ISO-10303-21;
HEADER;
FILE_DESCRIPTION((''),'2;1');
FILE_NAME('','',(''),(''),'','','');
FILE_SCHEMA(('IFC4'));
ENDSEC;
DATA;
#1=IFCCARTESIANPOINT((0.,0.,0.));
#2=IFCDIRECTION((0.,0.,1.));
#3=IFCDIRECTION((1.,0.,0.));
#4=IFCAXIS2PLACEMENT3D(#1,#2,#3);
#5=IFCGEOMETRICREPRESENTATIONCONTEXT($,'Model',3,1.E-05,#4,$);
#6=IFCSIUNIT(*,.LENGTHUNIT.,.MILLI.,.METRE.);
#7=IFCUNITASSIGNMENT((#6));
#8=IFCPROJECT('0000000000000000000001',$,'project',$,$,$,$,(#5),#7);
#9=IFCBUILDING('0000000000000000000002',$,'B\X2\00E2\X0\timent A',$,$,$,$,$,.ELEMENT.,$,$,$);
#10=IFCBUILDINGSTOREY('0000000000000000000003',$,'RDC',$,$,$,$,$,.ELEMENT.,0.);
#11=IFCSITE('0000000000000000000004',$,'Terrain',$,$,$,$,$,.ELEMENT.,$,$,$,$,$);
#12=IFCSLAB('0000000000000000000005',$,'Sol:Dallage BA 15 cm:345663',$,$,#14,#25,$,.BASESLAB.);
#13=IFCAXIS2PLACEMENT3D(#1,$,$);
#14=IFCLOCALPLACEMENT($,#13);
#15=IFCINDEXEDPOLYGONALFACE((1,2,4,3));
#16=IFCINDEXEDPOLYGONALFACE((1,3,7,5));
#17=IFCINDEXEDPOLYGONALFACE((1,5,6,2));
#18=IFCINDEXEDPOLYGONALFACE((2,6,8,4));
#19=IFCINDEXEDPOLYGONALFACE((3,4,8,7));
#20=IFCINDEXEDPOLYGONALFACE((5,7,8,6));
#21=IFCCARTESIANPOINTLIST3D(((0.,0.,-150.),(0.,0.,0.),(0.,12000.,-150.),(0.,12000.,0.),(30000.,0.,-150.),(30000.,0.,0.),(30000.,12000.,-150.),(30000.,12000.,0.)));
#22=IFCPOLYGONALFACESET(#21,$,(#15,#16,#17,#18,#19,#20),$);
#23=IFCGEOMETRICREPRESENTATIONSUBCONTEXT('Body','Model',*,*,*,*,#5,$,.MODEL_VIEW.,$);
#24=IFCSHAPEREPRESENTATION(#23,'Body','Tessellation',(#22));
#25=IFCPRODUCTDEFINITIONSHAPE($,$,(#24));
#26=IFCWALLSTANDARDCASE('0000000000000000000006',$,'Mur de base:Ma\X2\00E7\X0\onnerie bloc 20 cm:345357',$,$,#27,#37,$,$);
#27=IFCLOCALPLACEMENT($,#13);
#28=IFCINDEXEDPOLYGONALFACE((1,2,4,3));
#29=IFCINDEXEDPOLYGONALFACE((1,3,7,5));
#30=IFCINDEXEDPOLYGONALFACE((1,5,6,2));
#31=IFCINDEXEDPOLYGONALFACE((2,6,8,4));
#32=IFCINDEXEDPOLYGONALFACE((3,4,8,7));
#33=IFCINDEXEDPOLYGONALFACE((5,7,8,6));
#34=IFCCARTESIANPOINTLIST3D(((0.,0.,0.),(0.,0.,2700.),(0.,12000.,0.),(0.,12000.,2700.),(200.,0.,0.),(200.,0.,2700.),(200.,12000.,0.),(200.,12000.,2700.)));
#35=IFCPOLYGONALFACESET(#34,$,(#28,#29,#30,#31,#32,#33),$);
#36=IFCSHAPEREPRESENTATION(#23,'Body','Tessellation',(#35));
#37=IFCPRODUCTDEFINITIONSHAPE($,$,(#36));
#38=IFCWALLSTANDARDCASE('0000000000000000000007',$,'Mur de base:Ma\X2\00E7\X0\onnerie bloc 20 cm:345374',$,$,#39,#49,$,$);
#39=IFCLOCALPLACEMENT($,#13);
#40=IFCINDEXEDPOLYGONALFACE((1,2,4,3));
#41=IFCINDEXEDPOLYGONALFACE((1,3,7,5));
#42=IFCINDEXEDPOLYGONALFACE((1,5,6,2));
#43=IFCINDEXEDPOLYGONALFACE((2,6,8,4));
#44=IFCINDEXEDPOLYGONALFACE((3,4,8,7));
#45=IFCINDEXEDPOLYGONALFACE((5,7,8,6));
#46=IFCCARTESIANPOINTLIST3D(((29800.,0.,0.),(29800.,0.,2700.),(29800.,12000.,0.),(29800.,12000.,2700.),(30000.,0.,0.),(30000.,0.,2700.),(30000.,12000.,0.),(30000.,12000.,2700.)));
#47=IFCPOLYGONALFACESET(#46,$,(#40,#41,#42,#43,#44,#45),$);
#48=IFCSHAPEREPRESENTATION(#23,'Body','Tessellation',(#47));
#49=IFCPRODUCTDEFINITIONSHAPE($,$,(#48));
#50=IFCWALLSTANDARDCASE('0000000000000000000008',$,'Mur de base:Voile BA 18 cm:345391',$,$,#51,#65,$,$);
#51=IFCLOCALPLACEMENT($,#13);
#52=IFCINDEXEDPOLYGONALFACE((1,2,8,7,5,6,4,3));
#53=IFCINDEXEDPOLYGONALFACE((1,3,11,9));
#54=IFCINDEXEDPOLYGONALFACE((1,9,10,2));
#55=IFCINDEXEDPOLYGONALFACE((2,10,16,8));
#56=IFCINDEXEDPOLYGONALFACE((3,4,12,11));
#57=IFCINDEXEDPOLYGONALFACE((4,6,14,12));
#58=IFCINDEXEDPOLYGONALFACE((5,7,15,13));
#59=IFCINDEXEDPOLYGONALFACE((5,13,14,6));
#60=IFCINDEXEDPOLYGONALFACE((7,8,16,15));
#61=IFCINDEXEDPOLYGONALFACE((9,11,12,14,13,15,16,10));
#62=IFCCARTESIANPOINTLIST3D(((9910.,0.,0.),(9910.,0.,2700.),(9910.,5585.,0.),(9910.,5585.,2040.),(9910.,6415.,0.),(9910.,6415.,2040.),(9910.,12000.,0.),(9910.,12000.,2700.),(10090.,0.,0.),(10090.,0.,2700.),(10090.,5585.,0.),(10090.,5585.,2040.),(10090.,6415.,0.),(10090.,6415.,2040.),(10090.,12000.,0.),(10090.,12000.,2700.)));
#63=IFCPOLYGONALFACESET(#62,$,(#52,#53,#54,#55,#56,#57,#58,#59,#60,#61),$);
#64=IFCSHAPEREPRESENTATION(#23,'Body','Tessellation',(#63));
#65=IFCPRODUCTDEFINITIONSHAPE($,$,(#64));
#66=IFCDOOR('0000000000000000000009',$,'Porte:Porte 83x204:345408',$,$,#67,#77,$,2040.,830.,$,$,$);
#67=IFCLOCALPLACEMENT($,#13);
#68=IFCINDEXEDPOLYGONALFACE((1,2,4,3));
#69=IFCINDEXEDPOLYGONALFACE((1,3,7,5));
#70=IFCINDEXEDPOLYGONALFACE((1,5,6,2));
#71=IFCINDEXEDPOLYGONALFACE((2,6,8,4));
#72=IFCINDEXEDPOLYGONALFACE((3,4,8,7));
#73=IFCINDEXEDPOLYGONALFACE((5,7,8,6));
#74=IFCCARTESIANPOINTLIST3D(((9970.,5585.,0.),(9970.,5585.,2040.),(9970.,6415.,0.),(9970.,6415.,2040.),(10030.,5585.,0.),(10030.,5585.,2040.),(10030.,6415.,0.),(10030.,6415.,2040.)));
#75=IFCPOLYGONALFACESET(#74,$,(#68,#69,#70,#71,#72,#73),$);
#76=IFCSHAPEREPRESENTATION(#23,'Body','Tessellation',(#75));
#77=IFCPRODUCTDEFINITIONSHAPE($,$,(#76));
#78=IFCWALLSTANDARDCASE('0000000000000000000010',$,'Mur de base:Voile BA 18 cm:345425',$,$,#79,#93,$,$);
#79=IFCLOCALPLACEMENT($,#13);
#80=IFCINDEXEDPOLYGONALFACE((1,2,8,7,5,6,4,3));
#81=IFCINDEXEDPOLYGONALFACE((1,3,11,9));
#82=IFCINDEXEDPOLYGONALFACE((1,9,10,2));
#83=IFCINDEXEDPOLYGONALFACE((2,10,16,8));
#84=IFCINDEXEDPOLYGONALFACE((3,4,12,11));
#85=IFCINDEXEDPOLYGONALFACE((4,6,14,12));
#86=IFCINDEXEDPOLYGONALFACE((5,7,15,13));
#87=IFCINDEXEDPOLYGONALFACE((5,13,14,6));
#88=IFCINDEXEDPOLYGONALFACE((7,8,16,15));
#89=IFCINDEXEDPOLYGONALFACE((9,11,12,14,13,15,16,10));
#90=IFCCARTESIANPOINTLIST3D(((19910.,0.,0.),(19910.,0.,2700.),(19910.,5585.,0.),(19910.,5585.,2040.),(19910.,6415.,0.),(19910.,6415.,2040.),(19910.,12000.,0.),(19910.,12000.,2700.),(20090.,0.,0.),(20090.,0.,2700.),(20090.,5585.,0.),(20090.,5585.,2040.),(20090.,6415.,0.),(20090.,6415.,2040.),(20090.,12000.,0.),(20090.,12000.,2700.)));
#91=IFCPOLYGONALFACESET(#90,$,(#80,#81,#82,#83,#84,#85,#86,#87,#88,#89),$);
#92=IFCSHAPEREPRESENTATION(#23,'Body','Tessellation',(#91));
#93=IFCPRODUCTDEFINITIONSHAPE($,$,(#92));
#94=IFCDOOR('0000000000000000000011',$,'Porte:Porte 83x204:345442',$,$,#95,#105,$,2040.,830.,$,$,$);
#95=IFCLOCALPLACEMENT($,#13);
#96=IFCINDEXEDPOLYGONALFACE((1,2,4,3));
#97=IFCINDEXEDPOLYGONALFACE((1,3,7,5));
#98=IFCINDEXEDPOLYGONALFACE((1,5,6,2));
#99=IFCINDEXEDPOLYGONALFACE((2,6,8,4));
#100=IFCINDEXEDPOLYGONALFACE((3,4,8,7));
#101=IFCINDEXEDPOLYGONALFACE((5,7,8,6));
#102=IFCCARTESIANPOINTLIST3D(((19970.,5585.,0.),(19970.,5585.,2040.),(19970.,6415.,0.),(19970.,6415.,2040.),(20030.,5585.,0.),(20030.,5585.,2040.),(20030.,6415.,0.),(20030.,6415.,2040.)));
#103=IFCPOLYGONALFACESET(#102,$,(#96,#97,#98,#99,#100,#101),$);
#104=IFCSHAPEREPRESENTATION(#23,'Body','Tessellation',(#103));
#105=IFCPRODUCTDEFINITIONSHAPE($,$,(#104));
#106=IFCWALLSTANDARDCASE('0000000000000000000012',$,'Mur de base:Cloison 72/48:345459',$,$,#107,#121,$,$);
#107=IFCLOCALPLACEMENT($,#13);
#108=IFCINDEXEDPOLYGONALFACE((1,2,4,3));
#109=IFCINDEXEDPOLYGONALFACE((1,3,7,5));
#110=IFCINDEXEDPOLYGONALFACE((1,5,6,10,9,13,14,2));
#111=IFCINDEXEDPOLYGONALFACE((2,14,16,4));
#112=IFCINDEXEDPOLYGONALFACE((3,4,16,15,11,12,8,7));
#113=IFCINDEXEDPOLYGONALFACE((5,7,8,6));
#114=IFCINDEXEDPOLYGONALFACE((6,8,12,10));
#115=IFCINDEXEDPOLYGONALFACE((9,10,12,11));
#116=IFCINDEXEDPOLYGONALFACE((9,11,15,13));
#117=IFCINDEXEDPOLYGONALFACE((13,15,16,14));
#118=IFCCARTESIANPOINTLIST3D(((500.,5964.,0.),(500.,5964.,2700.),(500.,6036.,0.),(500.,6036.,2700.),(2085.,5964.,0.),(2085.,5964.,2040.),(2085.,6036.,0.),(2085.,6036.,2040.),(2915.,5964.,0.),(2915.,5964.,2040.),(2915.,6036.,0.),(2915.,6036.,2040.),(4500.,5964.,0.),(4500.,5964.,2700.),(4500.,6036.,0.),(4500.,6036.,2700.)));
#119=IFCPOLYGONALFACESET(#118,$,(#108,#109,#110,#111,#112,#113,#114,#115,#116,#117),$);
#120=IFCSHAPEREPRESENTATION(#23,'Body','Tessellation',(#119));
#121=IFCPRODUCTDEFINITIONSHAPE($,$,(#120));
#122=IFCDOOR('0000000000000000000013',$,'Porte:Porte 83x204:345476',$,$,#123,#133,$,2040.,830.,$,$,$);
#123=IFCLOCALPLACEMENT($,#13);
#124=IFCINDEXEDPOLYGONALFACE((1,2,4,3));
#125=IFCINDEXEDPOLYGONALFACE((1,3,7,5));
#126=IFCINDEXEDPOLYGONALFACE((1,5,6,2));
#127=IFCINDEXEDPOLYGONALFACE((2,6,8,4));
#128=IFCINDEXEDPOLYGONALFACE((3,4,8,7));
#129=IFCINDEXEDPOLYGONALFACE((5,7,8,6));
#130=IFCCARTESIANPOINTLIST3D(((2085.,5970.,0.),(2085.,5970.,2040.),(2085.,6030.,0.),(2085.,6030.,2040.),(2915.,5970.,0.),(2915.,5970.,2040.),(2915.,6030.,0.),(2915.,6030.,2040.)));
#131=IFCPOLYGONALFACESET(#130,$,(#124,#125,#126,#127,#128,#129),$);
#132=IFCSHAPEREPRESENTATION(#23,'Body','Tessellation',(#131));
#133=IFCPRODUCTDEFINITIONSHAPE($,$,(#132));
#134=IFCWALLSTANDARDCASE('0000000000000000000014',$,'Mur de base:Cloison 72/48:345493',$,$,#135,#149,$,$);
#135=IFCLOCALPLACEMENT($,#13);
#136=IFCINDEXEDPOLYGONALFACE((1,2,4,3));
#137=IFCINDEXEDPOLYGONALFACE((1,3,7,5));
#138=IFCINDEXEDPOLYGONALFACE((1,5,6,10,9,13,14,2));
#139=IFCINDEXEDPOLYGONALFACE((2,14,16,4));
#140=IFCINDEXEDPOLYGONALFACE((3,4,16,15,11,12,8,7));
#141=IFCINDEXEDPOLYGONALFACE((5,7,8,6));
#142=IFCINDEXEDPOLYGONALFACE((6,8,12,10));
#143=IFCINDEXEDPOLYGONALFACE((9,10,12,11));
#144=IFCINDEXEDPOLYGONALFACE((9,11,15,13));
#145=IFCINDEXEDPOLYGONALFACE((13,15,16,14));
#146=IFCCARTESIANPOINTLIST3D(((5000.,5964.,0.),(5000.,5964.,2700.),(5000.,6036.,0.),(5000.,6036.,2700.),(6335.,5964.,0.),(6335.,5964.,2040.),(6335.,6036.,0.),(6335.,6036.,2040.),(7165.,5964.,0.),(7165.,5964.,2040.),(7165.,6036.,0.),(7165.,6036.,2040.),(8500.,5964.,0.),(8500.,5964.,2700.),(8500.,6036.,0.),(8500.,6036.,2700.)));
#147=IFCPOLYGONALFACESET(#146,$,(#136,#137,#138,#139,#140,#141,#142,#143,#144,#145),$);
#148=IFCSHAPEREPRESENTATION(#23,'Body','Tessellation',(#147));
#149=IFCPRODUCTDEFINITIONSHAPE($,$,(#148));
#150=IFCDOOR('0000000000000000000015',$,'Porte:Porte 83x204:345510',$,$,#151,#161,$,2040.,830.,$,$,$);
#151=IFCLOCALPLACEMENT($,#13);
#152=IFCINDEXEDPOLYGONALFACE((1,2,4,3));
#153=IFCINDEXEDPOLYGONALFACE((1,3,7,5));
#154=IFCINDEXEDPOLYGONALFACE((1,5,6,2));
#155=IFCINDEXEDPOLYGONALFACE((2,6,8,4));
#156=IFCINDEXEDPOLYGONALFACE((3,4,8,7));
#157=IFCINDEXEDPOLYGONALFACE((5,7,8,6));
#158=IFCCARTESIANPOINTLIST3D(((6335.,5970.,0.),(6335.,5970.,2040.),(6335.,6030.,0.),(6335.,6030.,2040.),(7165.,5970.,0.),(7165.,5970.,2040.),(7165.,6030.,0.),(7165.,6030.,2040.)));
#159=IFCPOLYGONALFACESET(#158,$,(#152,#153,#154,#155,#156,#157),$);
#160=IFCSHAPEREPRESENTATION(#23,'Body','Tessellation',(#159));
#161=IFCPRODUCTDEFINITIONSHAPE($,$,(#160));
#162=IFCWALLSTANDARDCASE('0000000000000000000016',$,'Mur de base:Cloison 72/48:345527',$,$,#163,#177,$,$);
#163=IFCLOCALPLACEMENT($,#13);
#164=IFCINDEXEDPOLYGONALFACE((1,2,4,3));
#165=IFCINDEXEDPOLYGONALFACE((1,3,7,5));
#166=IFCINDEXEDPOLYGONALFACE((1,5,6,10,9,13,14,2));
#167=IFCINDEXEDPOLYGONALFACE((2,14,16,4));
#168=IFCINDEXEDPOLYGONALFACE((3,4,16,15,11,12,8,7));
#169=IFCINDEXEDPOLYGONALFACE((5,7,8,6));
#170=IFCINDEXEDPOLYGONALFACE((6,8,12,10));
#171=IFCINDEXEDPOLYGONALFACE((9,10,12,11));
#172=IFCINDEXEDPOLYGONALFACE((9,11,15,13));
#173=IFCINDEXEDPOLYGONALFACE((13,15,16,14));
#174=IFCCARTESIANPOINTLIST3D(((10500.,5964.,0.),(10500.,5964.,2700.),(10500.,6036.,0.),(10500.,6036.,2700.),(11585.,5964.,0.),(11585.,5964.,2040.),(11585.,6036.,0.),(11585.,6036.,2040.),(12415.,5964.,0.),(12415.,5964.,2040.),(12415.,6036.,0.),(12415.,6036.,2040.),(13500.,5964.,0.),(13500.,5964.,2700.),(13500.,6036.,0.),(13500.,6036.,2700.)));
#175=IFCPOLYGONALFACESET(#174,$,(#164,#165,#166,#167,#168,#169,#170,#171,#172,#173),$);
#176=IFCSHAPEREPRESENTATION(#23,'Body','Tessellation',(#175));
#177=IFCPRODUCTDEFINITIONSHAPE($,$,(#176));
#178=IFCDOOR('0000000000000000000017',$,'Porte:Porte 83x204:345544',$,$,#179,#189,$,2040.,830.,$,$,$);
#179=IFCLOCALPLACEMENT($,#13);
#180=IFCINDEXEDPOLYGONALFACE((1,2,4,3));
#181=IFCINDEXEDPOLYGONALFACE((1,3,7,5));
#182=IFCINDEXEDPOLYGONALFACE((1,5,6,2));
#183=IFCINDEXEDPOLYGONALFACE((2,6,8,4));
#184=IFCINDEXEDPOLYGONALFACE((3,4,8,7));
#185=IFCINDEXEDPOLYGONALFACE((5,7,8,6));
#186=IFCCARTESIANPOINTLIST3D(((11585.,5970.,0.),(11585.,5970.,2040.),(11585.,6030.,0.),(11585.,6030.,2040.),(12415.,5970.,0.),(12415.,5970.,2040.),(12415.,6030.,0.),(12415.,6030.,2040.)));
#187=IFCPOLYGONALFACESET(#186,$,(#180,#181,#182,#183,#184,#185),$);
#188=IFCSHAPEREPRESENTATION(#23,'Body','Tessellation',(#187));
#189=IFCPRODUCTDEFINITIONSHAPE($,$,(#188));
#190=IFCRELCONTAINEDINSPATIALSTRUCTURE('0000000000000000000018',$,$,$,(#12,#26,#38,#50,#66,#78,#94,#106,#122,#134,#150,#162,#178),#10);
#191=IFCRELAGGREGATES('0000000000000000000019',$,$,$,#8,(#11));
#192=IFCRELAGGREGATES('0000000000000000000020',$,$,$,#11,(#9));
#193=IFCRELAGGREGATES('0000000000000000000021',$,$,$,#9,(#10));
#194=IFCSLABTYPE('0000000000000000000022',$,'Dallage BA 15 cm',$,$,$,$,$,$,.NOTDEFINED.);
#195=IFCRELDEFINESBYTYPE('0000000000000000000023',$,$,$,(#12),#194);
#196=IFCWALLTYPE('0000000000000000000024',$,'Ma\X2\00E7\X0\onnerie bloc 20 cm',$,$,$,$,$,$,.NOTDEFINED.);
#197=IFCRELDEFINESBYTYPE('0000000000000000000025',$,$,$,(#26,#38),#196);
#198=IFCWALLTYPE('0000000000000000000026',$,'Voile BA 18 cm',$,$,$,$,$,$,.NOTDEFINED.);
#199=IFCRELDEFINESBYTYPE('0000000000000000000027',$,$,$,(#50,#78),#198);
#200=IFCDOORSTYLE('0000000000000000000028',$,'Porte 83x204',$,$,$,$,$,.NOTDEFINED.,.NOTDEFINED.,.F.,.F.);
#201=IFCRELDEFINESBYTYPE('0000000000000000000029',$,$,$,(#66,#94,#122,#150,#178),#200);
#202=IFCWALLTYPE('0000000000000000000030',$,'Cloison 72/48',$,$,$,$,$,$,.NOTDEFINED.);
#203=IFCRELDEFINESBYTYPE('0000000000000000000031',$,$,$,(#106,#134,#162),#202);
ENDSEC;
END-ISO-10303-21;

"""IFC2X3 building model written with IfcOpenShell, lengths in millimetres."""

from ifc_helpers import new_model, si_unit, frame, frame_2d, origin_with_axes, place, context, subcontext, project, spatial, rectangle, extrude, type_object, element, fill, save


model = new_model("IFC2X3")

# Units and contexts
model_context = context("Model", 3, precision=1e-05, world=origin_with_axes())
body_context = subcontext(model_context, "Body", "Model", "MODEL_VIEW")
ifc_project = project(units=[si_unit("LENGTHUNIT", "METRE", prefix="MILLI")], contexts=[model_context])

# Site, building, storey
site = spatial("IfcSite", under=ifc_project, Name="Terrain", CompositionType="ELEMENT")
building = spatial("IfcBuilding", under=site, Name="Bâtiment A", CompositionType="ELEMENT")
storey = spatial("IfcBuildingStorey", under=building, Name="RDC", CompositionType="ELEMENT", Elevation=0.0)

# Slab
slab_type = type_object("IfcSlabType", Name="Dallage BA 15 cm", PredefinedType="NOTDEFINED")
slab_placement = place(None, origin_with_axes())
element("IfcSlab", 1, at=slab_placement, inside=storey, type_object=slab_type, Name="Sol:Dallage BA 15 cm:345663", PredefinedType="BASESLAB", context=body_context, shape_type="SweptSolid", body=[
    extrude(rectangle(XDim=30000.0, YDim=12000.0, at=frame_2d((15000.0, 6000.0))), frame((0.0, 0.0, -150.0), z_axis=(0.0, 0.0, 1.0), x_axis=(1.0, 0.0, 0.0)), (0.0, 0.0, 1.0), 150.0),
])

# Walls
wall_type_1 = type_object("IfcWallType", Name="Maçonnerie bloc 20 cm", PredefinedType="NOTDEFINED")
wall_1_placement = place(None, origin_with_axes())
element("IfcWallStandardCase", 2, at=wall_1_placement, inside=storey, type_object=wall_type_1, Name="Mur de base:Maçonnerie bloc 20 cm:345357", context=body_context, shape_type="SweptSolid", body=[
    extrude(rectangle(XDim=200.0, YDim=12000.0, at=frame_2d((100.0, 6000.0))), origin_with_axes(), (0.0, 0.0, 1.0), 2700.0),
])
wall_2_placement = place(None, origin_with_axes())
element("IfcWallStandardCase", 3, at=wall_2_placement, inside=storey, type_object=wall_type_1, Name="Mur de base:Maçonnerie bloc 20 cm:345374", context=body_context, shape_type="SweptSolid", body=[
    extrude(rectangle(XDim=200.0, YDim=12000.0, at=frame_2d((29900.0, 6000.0))), origin_with_axes(), (0.0, 0.0, 1.0), 2700.0),
])

# Walls, openings, doors
wall_type_2 = type_object("IfcWallType", Name="Voile BA 18 cm", PredefinedType="NOTDEFINED")
wall_3_placement = place(None, origin_with_axes())
wall_3 = element("IfcWallStandardCase", 4, at=wall_3_placement, inside=storey, type_object=wall_type_2, Name="Mur de base:Voile BA 18 cm:345391", context=body_context, shape_type="SweptSolid", body=[
    extrude(rectangle(XDim=180.0, YDim=12000.0, at=frame_2d((10000.0, 6000.0))), origin_with_axes(), (0.0, 0.0, 1.0), 2700.0),
])
opening_1_placement = place(None, origin_with_axes())
opening_1 = element("IfcOpeningElement", 5, at=opening_1_placement, cuts=wall_3, context=body_context, shape_type="SweptSolid", body=[
    extrude(rectangle(XDim=300.0, YDim=830.0, at=frame_2d((10000.0, 6000.0))), origin_with_axes(), (0.0, 0.0, 1.0), 2040.0),
])
door_style = type_object("IfcDoorStyle", Name="Porte 83x204", ConstructionType="NOTDEFINED", OperationType="NOTDEFINED", ParameterTakesPrecedence=False, Sizeable=False)
door_1_placement = place(None, origin_with_axes())
door_1 = element("IfcDoor", 6, at=door_1_placement, inside=storey, type_object=door_style, Name="Porte:Porte 83x204:345408", OverallHeight=2040.0, OverallWidth=830.0, context=body_context, shape_type="SweptSolid", body=[
    extrude(rectangle(XDim=60.0, YDim=830.0, at=frame_2d((10000.0, 6000.0))), origin_with_axes(), (0.0, 0.0, 1.0), 2040.0),
])
fill(opening_1, door_1)
wall_4_placement = place(None, origin_with_axes())
wall_4 = element("IfcWallStandardCase", 7, at=wall_4_placement, inside=storey, type_object=wall_type_2, Name="Mur de base:Voile BA 18 cm:345425", context=body_context, shape_type="SweptSolid", body=[
    extrude(rectangle(XDim=180.0, YDim=12000.0, at=frame_2d((20000.0, 6000.0))), origin_with_axes(), (0.0, 0.0, 1.0), 2700.0),
])
opening_2_placement = place(None, origin_with_axes())
opening_2 = element("IfcOpeningElement", 8, at=opening_2_placement, cuts=wall_4, context=body_context, shape_type="SweptSolid", body=[
    extrude(rectangle(XDim=300.0, YDim=830.0, at=frame_2d((20000.0, 6000.0))), origin_with_axes(), (0.0, 0.0, 1.0), 2040.0),
])
door_2_placement = place(None, origin_with_axes())
door_2 = element("IfcDoor", 9, at=door_2_placement, inside=storey, type_object=door_style, Name="Porte:Porte 83x204:345442", OverallHeight=2040.0, OverallWidth=830.0, context=body_context, shape_type="SweptSolid", body=[
    extrude(rectangle(XDim=60.0, YDim=830.0, at=frame_2d((20000.0, 6000.0))), origin_with_axes(), (0.0, 0.0, 1.0), 2040.0),
])
fill(opening_2, door_2)
wall_type_3 = type_object("IfcWallType", Name="Cloison 72/48", PredefinedType="NOTDEFINED")
wall_5_placement = place(None, origin_with_axes())
wall_5 = element("IfcWallStandardCase", 10, at=wall_5_placement, inside=storey, type_object=wall_type_3, Name="Mur de base:Cloison 72/48:345459", context=body_context, shape_type="SweptSolid", body=[
    extrude(rectangle(XDim=4000.0, YDim=72.0, at=frame_2d((2500.0, 6000.0))), origin_with_axes(), (0.0, 0.0, 1.0), 2700.0),
])
opening_3_placement = place(None, origin_with_axes())
opening_3 = element("IfcOpeningElement", 11, at=opening_3_placement, cuts=wall_5, context=body_context, shape_type="SweptSolid", body=[
    extrude(rectangle(XDim=830.0, YDim=192.0, at=frame_2d((2500.0, 6000.0))), origin_with_axes(), (0.0, 0.0, 1.0), 2040.0),
])
door_3_placement = place(None, origin_with_axes())
door_3 = element("IfcDoor", 12, at=door_3_placement, inside=storey, type_object=door_style, Name="Porte:Porte 83x204:345476", OverallHeight=2040.0, OverallWidth=830.0, context=body_context, shape_type="SweptSolid", body=[
    extrude(rectangle(XDim=830.0, YDim=60.0, at=frame_2d((2500.0, 6000.0))), origin_with_axes(), (0.0, 0.0, 1.0), 2040.0),
])
fill(opening_3, door_3)
wall_6_placement = place(None, origin_with_axes())
wall_6 = element("IfcWallStandardCase", 13, at=wall_6_placement, inside=storey, type_object=wall_type_3, Name="Mur de base:Cloison 72/48:345493", context=body_context, shape_type="SweptSolid", body=[
    extrude(rectangle(XDim=3500.0, YDim=72.0, at=frame_2d((6750.0, 6000.0))), origin_with_axes(), (0.0, 0.0, 1.0), 2700.0),
])
opening_4_placement = place(None, origin_with_axes())
opening_4 = element("IfcOpeningElement", 14, at=opening_4_placement, cuts=wall_6, context=body_context, shape_type="SweptSolid", body=[
    extrude(rectangle(XDim=830.0, YDim=192.0, at=frame_2d((6750.0, 6000.0))), origin_with_axes(), (0.0, 0.0, 1.0), 2040.0),
])
door_4_placement = place(None, origin_with_axes())
door_4 = element("IfcDoor", 15, at=door_4_placement, inside=storey, type_object=door_style, Name="Porte:Porte 83x204:345510", OverallHeight=2040.0, OverallWidth=830.0, context=body_context, shape_type="SweptSolid", body=[
    extrude(rectangle(XDim=830.0, YDim=60.0, at=frame_2d((6750.0, 6000.0))), origin_with_axes(), (0.0, 0.0, 1.0), 2040.0),
])
fill(opening_4, door_4)
wall_7_placement = place(None, origin_with_axes())
wall_7 = element("IfcWallStandardCase", 16, at=wall_7_placement, inside=storey, type_object=wall_type_3, Name="Mur de base:Cloison 72/48:345527", context=body_context, shape_type="SweptSolid", body=[
    extrude(rectangle(XDim=3000.0, YDim=72.0, at=frame_2d((12000.0, 6000.0))), origin_with_axes(), (0.0, 0.0, 1.0), 2700.0),
])
opening_5_placement = place(None, origin_with_axes())
opening_5 = element("IfcOpeningElement", 17, at=opening_5_placement, cuts=wall_7, context=body_context, shape_type="SweptSolid", body=[
    extrude(rectangle(XDim=830.0, YDim=192.0, at=frame_2d((12000.0, 6000.0))), origin_with_axes(), (0.0, 0.0, 1.0), 2040.0),
])
door_5_placement = place(None, origin_with_axes())
door_5 = element("IfcDoor", 18, at=door_5_placement, inside=storey, type_object=door_style, Name="Porte:Porte 83x204:345544", OverallHeight=2040.0, OverallWidth=830.0, context=body_context, shape_type="SweptSolid", body=[
    extrude(rectangle(XDim=830.0, YDim=60.0, at=frame_2d((12000.0, 6000.0))), origin_with_axes(), (0.0, 0.0, 1.0), 2040.0),
])
fill(opening_5, door_5)

save(model, "model.ifc")
